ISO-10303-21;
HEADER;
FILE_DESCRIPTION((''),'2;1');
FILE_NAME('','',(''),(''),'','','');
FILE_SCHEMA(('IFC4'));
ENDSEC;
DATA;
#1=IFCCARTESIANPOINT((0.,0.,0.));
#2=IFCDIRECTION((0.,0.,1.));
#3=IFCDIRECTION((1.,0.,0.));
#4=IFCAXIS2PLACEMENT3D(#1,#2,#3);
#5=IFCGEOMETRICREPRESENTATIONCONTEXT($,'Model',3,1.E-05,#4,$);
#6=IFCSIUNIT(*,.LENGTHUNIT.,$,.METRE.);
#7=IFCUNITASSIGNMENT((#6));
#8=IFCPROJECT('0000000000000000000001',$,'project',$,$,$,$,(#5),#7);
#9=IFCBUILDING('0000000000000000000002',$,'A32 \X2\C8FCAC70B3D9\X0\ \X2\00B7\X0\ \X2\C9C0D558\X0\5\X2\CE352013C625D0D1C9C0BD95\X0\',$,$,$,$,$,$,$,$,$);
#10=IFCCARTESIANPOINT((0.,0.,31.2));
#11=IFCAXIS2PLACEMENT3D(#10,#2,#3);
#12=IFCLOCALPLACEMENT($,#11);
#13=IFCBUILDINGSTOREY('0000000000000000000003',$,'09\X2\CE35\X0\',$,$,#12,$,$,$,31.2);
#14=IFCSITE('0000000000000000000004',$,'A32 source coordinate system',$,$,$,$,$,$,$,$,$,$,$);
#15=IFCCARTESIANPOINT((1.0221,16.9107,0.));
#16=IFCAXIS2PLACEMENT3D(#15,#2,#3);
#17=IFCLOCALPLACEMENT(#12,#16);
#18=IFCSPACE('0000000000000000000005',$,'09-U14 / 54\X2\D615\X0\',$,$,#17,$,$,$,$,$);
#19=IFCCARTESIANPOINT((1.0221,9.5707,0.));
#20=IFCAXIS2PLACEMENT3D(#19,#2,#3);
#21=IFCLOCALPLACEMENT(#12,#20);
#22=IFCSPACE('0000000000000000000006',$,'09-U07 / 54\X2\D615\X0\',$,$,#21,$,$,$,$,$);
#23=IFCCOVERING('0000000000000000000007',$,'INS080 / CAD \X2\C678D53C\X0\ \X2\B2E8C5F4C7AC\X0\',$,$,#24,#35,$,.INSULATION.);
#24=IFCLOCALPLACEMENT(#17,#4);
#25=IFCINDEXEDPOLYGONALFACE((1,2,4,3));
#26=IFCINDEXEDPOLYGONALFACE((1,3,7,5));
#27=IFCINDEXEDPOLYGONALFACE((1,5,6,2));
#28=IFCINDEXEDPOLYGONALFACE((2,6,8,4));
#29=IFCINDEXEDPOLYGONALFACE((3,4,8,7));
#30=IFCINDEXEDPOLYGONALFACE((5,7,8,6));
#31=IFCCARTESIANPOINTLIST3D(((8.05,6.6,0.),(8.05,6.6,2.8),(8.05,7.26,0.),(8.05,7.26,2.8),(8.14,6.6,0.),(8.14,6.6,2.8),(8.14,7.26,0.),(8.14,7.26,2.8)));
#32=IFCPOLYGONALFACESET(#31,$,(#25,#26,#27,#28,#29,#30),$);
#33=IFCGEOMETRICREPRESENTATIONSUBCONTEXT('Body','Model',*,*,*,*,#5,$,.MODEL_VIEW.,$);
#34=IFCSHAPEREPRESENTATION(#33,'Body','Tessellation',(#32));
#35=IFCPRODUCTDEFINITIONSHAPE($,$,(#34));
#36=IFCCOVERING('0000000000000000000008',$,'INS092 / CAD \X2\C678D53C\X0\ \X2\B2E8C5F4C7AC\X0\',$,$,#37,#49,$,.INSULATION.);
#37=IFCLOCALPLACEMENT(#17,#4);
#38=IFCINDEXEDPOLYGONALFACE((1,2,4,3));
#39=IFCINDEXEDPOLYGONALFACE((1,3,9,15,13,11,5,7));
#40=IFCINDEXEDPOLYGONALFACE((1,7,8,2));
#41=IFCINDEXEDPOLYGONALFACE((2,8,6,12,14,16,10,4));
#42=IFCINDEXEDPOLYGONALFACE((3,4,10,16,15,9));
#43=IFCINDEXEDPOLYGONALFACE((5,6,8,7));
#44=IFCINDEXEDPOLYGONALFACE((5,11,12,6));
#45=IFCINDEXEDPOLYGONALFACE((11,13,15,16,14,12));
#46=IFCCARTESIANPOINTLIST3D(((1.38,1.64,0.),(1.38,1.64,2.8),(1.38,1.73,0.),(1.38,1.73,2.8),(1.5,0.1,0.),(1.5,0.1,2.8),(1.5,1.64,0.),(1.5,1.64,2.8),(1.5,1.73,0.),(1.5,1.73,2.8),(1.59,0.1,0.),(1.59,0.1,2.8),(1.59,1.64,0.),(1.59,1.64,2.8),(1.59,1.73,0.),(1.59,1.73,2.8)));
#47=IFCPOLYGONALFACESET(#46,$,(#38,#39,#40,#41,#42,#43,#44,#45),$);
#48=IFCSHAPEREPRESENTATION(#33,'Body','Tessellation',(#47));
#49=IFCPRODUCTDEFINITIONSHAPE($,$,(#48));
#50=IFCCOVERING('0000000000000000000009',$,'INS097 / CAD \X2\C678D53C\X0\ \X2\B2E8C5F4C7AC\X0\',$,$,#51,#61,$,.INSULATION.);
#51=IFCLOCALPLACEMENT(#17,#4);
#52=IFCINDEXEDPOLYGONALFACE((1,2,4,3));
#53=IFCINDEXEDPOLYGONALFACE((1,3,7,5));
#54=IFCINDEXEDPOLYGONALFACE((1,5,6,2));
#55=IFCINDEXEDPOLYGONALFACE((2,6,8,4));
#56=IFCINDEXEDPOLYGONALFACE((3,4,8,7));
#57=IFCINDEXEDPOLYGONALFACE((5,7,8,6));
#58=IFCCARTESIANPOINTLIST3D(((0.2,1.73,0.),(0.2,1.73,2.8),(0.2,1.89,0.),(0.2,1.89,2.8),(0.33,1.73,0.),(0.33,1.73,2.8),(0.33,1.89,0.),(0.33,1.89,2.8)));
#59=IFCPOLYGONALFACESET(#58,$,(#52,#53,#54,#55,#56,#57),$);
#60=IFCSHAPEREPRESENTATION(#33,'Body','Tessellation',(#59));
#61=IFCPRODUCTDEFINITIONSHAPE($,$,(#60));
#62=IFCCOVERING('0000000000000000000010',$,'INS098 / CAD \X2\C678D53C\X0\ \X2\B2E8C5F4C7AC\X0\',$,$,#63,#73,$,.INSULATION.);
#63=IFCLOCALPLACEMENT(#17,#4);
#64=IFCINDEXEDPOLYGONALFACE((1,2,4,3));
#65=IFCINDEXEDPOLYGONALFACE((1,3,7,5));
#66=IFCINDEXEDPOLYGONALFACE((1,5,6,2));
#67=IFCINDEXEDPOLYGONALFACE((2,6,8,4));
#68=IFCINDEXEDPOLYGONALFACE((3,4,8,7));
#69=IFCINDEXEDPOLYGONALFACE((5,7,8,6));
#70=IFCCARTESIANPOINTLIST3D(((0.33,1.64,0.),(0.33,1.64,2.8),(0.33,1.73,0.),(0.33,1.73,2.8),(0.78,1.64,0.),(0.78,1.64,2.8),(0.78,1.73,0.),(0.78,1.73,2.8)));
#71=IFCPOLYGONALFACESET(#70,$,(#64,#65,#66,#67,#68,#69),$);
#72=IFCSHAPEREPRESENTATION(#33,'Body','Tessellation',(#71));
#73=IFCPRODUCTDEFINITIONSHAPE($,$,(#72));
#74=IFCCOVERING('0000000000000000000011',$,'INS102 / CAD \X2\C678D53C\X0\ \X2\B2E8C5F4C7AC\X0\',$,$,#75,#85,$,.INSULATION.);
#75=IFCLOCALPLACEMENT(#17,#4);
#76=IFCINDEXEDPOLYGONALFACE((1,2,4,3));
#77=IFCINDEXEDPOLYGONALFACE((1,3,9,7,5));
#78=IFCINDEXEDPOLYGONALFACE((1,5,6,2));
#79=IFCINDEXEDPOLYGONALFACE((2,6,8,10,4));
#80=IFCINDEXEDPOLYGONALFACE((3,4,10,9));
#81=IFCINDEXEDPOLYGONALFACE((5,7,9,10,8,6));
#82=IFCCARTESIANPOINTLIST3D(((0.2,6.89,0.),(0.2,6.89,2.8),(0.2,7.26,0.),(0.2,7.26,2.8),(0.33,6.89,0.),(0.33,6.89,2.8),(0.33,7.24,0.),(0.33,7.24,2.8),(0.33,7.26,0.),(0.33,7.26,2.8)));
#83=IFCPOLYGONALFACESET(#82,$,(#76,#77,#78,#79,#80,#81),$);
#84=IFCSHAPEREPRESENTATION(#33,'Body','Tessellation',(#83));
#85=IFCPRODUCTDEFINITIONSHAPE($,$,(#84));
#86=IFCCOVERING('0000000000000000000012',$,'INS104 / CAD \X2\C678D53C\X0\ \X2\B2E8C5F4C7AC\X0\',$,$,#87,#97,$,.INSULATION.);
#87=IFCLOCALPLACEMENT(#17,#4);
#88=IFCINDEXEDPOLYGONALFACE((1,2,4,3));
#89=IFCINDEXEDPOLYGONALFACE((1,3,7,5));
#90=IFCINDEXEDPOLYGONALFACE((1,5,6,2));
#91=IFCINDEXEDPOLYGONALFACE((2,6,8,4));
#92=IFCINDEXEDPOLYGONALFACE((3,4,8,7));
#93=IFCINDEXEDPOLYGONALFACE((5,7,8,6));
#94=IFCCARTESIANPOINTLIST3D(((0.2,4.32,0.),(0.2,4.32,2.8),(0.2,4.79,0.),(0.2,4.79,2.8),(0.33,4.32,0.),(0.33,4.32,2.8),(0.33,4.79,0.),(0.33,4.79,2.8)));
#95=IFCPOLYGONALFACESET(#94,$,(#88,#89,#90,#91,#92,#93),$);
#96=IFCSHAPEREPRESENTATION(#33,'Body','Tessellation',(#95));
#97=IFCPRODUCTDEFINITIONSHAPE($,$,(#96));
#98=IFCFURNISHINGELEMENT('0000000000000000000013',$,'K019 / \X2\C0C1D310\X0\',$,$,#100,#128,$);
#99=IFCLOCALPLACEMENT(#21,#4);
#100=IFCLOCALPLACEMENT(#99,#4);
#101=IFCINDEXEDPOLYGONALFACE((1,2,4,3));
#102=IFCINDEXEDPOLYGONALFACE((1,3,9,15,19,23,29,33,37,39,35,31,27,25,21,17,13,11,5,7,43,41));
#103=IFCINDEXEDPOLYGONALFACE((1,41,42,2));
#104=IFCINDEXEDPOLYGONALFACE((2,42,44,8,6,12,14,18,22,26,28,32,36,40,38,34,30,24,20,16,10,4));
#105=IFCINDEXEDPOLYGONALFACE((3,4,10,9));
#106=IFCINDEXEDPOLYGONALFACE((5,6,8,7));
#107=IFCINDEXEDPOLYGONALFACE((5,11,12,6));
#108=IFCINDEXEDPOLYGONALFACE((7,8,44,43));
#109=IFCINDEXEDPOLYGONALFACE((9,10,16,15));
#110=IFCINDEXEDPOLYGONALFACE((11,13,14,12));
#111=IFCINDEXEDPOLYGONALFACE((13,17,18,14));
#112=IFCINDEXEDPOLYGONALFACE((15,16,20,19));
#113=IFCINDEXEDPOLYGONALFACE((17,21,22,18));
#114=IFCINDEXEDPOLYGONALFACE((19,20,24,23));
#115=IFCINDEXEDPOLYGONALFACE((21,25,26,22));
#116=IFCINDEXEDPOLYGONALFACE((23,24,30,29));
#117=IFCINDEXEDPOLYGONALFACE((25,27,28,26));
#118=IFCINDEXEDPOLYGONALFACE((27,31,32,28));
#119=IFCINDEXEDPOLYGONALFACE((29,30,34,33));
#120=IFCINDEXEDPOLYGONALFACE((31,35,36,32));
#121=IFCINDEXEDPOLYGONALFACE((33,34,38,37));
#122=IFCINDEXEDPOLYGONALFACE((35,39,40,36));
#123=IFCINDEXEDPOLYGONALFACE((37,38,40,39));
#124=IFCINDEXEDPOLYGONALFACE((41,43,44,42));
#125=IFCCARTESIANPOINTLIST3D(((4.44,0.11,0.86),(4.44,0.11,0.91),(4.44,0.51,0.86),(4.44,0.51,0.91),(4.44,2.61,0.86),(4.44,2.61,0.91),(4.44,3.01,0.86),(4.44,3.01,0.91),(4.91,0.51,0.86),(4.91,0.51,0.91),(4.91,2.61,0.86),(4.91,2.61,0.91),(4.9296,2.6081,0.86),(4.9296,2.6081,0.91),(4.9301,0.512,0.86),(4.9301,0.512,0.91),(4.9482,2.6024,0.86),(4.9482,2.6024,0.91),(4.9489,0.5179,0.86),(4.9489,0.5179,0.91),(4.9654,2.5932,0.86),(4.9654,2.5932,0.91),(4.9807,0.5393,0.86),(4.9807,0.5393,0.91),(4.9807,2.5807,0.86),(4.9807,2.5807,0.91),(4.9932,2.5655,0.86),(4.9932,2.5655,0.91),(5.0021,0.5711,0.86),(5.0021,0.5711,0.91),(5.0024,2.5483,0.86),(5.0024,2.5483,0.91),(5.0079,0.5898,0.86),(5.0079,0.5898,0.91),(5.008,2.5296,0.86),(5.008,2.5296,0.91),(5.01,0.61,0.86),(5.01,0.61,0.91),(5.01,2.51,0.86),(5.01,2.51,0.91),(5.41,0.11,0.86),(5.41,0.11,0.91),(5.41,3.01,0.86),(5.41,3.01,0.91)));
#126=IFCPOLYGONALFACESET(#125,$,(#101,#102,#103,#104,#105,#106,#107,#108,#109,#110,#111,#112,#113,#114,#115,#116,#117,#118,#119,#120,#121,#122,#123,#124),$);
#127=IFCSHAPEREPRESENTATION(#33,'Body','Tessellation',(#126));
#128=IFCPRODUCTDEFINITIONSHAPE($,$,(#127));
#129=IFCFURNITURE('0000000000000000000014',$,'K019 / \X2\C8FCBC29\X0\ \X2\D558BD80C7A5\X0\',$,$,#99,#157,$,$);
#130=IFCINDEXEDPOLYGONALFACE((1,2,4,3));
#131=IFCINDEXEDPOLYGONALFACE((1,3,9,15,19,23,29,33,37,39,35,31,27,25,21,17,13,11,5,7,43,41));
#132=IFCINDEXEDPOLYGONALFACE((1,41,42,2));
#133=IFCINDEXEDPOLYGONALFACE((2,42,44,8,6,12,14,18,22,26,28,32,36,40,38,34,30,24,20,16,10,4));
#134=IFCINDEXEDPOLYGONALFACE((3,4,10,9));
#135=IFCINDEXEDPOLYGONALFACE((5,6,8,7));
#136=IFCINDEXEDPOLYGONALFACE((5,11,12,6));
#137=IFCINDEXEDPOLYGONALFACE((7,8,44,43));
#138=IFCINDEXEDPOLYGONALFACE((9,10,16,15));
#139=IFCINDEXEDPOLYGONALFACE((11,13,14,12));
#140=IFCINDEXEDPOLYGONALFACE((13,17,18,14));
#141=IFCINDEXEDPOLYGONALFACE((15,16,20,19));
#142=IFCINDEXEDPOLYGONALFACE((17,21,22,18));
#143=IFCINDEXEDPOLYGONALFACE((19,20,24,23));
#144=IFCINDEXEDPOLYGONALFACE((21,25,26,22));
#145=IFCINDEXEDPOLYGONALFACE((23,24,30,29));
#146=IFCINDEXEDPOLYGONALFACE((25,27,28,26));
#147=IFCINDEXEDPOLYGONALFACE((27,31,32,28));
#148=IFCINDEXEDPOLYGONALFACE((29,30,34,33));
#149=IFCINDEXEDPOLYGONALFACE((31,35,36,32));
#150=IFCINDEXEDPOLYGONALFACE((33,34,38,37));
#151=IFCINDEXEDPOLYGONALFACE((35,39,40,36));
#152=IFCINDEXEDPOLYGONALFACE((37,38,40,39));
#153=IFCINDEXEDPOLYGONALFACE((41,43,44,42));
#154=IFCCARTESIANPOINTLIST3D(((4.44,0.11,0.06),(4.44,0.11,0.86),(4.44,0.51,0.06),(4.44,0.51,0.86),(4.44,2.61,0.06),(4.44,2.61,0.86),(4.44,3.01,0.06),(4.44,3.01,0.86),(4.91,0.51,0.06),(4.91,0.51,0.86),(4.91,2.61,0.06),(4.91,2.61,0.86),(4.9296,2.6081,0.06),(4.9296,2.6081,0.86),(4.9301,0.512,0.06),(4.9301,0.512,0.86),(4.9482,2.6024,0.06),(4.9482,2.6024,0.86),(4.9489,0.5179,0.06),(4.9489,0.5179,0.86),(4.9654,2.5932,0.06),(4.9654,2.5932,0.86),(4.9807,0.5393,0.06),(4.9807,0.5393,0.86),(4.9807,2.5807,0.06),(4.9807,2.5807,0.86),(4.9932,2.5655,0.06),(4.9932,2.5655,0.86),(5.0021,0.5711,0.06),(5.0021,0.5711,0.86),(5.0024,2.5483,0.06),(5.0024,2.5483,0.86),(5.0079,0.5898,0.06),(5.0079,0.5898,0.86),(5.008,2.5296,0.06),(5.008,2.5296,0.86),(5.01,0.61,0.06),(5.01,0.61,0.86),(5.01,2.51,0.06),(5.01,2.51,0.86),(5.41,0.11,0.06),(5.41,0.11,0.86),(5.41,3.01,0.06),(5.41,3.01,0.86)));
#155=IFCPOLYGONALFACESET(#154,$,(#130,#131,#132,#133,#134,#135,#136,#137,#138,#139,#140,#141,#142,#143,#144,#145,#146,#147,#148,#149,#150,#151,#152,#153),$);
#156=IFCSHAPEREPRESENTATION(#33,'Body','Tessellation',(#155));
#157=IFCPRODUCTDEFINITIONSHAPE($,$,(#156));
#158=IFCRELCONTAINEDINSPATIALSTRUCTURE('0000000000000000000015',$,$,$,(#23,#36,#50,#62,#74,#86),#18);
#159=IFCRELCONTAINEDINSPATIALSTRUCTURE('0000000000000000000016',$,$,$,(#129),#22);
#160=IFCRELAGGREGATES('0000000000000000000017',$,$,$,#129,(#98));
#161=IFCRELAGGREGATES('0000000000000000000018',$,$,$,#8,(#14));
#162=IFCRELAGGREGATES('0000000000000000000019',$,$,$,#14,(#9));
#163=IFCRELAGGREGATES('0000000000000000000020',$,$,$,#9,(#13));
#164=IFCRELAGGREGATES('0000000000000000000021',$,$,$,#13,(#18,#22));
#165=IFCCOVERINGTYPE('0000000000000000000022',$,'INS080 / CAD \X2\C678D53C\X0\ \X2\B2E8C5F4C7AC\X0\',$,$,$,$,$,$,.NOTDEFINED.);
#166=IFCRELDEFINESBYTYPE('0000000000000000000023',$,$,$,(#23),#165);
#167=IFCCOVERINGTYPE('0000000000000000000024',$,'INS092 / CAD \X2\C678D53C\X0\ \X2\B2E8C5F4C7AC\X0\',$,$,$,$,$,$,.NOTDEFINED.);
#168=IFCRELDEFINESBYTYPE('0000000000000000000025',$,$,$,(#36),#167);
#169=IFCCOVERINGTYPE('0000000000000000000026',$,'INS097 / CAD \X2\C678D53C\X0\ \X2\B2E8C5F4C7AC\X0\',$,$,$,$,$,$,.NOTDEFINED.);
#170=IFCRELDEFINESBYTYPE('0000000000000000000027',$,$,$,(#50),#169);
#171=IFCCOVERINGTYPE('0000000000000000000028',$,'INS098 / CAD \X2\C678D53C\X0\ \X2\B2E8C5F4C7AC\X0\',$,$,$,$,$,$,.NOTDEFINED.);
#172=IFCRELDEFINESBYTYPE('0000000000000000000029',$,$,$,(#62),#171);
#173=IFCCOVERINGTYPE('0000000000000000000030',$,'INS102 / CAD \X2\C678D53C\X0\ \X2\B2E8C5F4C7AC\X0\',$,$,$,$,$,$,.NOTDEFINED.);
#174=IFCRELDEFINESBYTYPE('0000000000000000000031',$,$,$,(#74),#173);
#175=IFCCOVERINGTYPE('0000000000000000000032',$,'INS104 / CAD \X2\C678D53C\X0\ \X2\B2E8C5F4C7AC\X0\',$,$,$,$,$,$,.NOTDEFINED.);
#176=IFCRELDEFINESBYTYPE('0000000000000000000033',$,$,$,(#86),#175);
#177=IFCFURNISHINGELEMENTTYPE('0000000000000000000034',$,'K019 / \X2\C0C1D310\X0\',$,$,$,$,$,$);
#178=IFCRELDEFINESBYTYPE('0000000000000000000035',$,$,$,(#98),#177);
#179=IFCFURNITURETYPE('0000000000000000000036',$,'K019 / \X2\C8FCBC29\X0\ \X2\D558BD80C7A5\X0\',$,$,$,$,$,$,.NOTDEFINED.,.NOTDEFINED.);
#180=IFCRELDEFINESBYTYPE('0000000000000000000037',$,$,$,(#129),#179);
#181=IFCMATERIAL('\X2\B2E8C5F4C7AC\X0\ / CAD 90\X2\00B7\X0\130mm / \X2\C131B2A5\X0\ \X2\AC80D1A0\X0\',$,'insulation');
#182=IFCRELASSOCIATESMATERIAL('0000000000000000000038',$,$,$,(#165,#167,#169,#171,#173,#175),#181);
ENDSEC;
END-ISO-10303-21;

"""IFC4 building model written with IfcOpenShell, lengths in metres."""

from ifc_helpers import new_model, si_unit, frame, origin, origin_with_axes, place, context, subcontext, project, spatial, polyline, outline, extrude, source, transform, mapped, material, type_object, type_shapes, element, aggregate, save


model = new_model("IFC4")

# Units and contexts
model_context = context("Model", 3, precision=1e-05, world=origin_with_axes())
body_context = subcontext(model_context, "Body", "Model", "MODEL_VIEW")
ifc_project = project(units=[si_unit("LENGTHUNIT", "METRE")], contexts=[model_context])

# Site, building, storey, space
storey_placement = place(None, frame((0.0, 0.0, 31.2), z_axis=(0.0, 0.0, 1.0), x_axis=(1.0, 0.0, 0.0)))
space_1_placement = place(storey_placement, frame((1.0221, 16.9107, 0.0), z_axis=(0.0, 0.0, 1.0), x_axis=(1.0, 0.0, 0.0)))
site = spatial("IfcSite", under=ifc_project, Name="A32 source coordinate system")
building = spatial("IfcBuilding", under=site, Name="A32 주거동 · 지하5층–옥탑지붕")
storey = spatial("IfcBuildingStorey", under=building, at=storey_placement, Name="09층", Elevation=31.2)
space_1 = spatial("IfcSpace", under=storey, at=space_1_placement, Name="09-U14 / 54형")

# Coverings
ifc_material = material(Name="단열재 / CAD 90·130mm / 성능 검토", Category="insulation")
covering_type_1 = type_object("IfcCoveringType", Name="INS080 / CAD 외피 단열재", PredefinedType="NOTDEFINED", material=ifc_material)
shared_shape_1 = source(origin(), body_context, "Body", "SweptSolid", [
    extrude(outline(polyline([(8.14, 7.26), (8.14, 6.6), (8.05, 6.6), (8.05, 7.26), (8.14, 7.26)])), origin(), (0.0, 0.0, 1.0), 2.8),
])
type_shapes(covering_type_1, [shared_shape_1])
covering_1_placement = place(space_1_placement, origin_with_axes())
element("IfcCovering", 1, at=covering_1_placement, inside=space_1, type_object=covering_type_1, Name="INS080 / CAD 외피 단열재", PredefinedType="INSULATION", context=body_context, shape_type="MappedRepresentation", body=[
    mapped(shared_shape_1, transform((0.0, 0.0, 0.0), scale=1.0)),
])
covering_type_2 = type_object("IfcCoveringType", Name="INS092 / CAD 외피 단열재", PredefinedType="NOTDEFINED", material=ifc_material)
shared_shape_2 = source(origin(), body_context, "Body", "SweptSolid", [
    extrude(outline(polyline([(1.59, 1.73), (1.59, 1.64), (1.59, 0.1), (1.5, 0.1), (1.5, 1.64), (1.38, 1.64), (1.38, 1.73), (1.5, 1.73), (1.59, 1.73)])), origin(), (0.0, 0.0, 1.0), 2.8),
])
type_shapes(covering_type_2, [shared_shape_2])
covering_2_placement = place(space_1_placement, origin_with_axes())
element("IfcCovering", 2, at=covering_2_placement, inside=space_1, type_object=covering_type_2, Name="INS092 / CAD 외피 단열재", PredefinedType="INSULATION", context=body_context, shape_type="MappedRepresentation", body=[
    mapped(shared_shape_2, transform((0.0, 0.0, 0.0), scale=1.0)),
])
covering_type_3 = type_object("IfcCoveringType", Name="INS097 / CAD 외피 단열재", PredefinedType="NOTDEFINED", material=ifc_material)
shared_shape_3 = source(origin(), body_context, "Body", "SweptSolid", [
    extrude(outline(polyline([(0.33, 1.89), (0.33, 1.73), (0.2, 1.73), (0.2, 1.89), (0.33, 1.89)])), origin(), (0.0, 0.0, 1.0), 2.8),
])
type_shapes(covering_type_3, [shared_shape_3])
covering_3_placement = place(space_1_placement, origin_with_axes())
element("IfcCovering", 3, at=covering_3_placement, inside=space_1, type_object=covering_type_3, Name="INS097 / CAD 외피 단열재", PredefinedType="INSULATION", context=body_context, shape_type="MappedRepresentation", body=[
    mapped(shared_shape_3, transform((0.0, 0.0, 0.0), scale=1.0)),
])
covering_type_4 = type_object("IfcCoveringType", Name="INS098 / CAD 외피 단열재", PredefinedType="NOTDEFINED", material=ifc_material)
shared_shape_4 = source(origin(), body_context, "Body", "SweptSolid", [
    extrude(outline(polyline([(0.78, 1.73), (0.78, 1.64), (0.33, 1.64), (0.33, 1.73), (0.78, 1.73)])), origin(), (0.0, 0.0, 1.0), 2.8),
])
type_shapes(covering_type_4, [shared_shape_4])
covering_4_placement = place(space_1_placement, origin_with_axes())
element("IfcCovering", 4, at=covering_4_placement, inside=space_1, type_object=covering_type_4, Name="INS098 / CAD 외피 단열재", PredefinedType="INSULATION", context=body_context, shape_type="MappedRepresentation", body=[
    mapped(shared_shape_4, transform((0.0, 0.0, 0.0), scale=1.0)),
])
covering_type_5 = type_object("IfcCoveringType", Name="INS102 / CAD 외피 단열재", PredefinedType="NOTDEFINED", material=ifc_material)
shared_shape_5 = source(origin(), body_context, "Body", "SweptSolid", [
    extrude(outline(polyline([(0.33, 7.26), (0.33, 7.24), (0.33, 6.89), (0.2, 6.89), (0.2, 7.26), (0.33, 7.26)])), origin(), (0.0, 0.0, 1.0), 2.8),
])
type_shapes(covering_type_5, [shared_shape_5])
covering_5_placement = place(space_1_placement, origin_with_axes())
element("IfcCovering", 5, at=covering_5_placement, inside=space_1, type_object=covering_type_5, Name="INS102 / CAD 외피 단열재", PredefinedType="INSULATION", context=body_context, shape_type="MappedRepresentation", body=[
    mapped(shared_shape_5, transform((0.0, 0.0, 0.0), scale=1.0)),
])
covering_type_6 = type_object("IfcCoveringType", Name="INS104 / CAD 외피 단열재", PredefinedType="NOTDEFINED", material=ifc_material)
shared_shape_6 = source(origin(), body_context, "Body", "SweptSolid", [
    extrude(outline(polyline([(0.33, 4.32), (0.2, 4.32), (0.2, 4.79), (0.33, 4.79), (0.33, 4.32)])), origin(), (0.0, 0.0, 1.0), 2.8),
])
type_shapes(covering_type_6, [shared_shape_6])
covering_6_placement = place(space_1_placement, origin_with_axes())
element("IfcCovering", 6, at=covering_6_placement, inside=space_1, type_object=covering_type_6, Name="INS104 / CAD 외피 단열재", PredefinedType="INSULATION", context=body_context, shape_type="MappedRepresentation", body=[
    mapped(shared_shape_6, transform((0.0, 0.0, 0.0), scale=1.0)),
])

# Furnishing element
furnishing_element_type = type_object("IfcFurnishingElementType", Name="K019 / 상판")
shared_shape_7 = source(origin(), body_context, "Body", "SweptSolid", [
    extrude(outline(polyline([(4.91, 0.51), (4.9301, 0.512), (4.9489, 0.5179), (4.9807, 0.5393), (5.0021, 0.5711), (5.0079, 0.5898), (5.01, 0.61), (5.01, 2.51), (5.008, 2.5296), (5.0024, 2.5483), (4.9932, 2.5655), (4.9807, 2.5807), (4.9654, 2.5932), (4.9482, 2.6024), (4.9296, 2.6081), (4.91, 2.61), (4.44, 2.61), (4.44, 3.01), (5.41, 3.01), (5.41, 0.11), (4.44, 0.11), (4.44, 0.51), (4.91, 0.51)])), frame((0.0, 0.0, 0.86)), (0.0, 0.0, 1.0), 0.05),
])
type_shapes(furnishing_element_type, [shared_shape_7])
space_2_placement = place(storey_placement, frame((1.0221, 9.5707, 0.0), z_axis=(0.0, 0.0, 1.0), x_axis=(1.0, 0.0, 0.0)))
furniture_placement = place(space_2_placement, origin_with_axes())
furnishing_placement = place(furniture_placement, origin_with_axes())
furnishing = element("IfcFurnishingElement", 7, at=furnishing_placement, type_object=furnishing_element_type, Name="K019 / 상판", context=body_context, shape_type="MappedRepresentation", body=[
    mapped(shared_shape_7, transform((0.0, 0.0, 0.0), scale=1.0)),
])

# Shared definitions
space_2 = spatial("IfcSpace", under=storey, at=space_2_placement, Name="09-U07 / 54형")

# Furniture
furniture_type = type_object("IfcFurnitureType", Name="K019 / 주방 하부장", AssemblyPlace="NOTDEFINED", PredefinedType="NOTDEFINED")
shared_shape_8 = source(origin(), body_context, "Body", "SweptSolid", [
    extrude(outline(polyline([(4.44, 0.51), (4.91, 0.51), (4.9301, 0.512), (4.9489, 0.5179), (4.9807, 0.5393), (5.0021, 0.5711), (5.0079, 0.5898), (5.01, 0.61), (5.01, 2.51), (5.008, 2.5296), (5.0024, 2.5483), (4.9932, 2.5655), (4.9807, 2.5807), (4.9654, 2.5932), (4.9482, 2.6024), (4.9296, 2.6081), (4.91, 2.61), (4.44, 2.61), (4.44, 3.01), (5.41, 3.01), (5.41, 0.11), (4.44, 0.11), (4.44, 0.51)])), frame((0.0, 0.0, 0.06)), (0.0, 0.0, 1.0), 0.8),
])
type_shapes(furniture_type, [shared_shape_8])
furniture = element("IfcFurniture", 8, at=furniture_placement, inside=space_2, type_object=furniture_type, Name="K019 / 주방 하부장", context=body_context, shape_type="MappedRepresentation", body=[
    mapped(shared_shape_8, transform((0.0, 0.0, 0.0), scale=1.0)),
])
aggregate(furniture, [furnishing])

save(model, "model.ifc")
